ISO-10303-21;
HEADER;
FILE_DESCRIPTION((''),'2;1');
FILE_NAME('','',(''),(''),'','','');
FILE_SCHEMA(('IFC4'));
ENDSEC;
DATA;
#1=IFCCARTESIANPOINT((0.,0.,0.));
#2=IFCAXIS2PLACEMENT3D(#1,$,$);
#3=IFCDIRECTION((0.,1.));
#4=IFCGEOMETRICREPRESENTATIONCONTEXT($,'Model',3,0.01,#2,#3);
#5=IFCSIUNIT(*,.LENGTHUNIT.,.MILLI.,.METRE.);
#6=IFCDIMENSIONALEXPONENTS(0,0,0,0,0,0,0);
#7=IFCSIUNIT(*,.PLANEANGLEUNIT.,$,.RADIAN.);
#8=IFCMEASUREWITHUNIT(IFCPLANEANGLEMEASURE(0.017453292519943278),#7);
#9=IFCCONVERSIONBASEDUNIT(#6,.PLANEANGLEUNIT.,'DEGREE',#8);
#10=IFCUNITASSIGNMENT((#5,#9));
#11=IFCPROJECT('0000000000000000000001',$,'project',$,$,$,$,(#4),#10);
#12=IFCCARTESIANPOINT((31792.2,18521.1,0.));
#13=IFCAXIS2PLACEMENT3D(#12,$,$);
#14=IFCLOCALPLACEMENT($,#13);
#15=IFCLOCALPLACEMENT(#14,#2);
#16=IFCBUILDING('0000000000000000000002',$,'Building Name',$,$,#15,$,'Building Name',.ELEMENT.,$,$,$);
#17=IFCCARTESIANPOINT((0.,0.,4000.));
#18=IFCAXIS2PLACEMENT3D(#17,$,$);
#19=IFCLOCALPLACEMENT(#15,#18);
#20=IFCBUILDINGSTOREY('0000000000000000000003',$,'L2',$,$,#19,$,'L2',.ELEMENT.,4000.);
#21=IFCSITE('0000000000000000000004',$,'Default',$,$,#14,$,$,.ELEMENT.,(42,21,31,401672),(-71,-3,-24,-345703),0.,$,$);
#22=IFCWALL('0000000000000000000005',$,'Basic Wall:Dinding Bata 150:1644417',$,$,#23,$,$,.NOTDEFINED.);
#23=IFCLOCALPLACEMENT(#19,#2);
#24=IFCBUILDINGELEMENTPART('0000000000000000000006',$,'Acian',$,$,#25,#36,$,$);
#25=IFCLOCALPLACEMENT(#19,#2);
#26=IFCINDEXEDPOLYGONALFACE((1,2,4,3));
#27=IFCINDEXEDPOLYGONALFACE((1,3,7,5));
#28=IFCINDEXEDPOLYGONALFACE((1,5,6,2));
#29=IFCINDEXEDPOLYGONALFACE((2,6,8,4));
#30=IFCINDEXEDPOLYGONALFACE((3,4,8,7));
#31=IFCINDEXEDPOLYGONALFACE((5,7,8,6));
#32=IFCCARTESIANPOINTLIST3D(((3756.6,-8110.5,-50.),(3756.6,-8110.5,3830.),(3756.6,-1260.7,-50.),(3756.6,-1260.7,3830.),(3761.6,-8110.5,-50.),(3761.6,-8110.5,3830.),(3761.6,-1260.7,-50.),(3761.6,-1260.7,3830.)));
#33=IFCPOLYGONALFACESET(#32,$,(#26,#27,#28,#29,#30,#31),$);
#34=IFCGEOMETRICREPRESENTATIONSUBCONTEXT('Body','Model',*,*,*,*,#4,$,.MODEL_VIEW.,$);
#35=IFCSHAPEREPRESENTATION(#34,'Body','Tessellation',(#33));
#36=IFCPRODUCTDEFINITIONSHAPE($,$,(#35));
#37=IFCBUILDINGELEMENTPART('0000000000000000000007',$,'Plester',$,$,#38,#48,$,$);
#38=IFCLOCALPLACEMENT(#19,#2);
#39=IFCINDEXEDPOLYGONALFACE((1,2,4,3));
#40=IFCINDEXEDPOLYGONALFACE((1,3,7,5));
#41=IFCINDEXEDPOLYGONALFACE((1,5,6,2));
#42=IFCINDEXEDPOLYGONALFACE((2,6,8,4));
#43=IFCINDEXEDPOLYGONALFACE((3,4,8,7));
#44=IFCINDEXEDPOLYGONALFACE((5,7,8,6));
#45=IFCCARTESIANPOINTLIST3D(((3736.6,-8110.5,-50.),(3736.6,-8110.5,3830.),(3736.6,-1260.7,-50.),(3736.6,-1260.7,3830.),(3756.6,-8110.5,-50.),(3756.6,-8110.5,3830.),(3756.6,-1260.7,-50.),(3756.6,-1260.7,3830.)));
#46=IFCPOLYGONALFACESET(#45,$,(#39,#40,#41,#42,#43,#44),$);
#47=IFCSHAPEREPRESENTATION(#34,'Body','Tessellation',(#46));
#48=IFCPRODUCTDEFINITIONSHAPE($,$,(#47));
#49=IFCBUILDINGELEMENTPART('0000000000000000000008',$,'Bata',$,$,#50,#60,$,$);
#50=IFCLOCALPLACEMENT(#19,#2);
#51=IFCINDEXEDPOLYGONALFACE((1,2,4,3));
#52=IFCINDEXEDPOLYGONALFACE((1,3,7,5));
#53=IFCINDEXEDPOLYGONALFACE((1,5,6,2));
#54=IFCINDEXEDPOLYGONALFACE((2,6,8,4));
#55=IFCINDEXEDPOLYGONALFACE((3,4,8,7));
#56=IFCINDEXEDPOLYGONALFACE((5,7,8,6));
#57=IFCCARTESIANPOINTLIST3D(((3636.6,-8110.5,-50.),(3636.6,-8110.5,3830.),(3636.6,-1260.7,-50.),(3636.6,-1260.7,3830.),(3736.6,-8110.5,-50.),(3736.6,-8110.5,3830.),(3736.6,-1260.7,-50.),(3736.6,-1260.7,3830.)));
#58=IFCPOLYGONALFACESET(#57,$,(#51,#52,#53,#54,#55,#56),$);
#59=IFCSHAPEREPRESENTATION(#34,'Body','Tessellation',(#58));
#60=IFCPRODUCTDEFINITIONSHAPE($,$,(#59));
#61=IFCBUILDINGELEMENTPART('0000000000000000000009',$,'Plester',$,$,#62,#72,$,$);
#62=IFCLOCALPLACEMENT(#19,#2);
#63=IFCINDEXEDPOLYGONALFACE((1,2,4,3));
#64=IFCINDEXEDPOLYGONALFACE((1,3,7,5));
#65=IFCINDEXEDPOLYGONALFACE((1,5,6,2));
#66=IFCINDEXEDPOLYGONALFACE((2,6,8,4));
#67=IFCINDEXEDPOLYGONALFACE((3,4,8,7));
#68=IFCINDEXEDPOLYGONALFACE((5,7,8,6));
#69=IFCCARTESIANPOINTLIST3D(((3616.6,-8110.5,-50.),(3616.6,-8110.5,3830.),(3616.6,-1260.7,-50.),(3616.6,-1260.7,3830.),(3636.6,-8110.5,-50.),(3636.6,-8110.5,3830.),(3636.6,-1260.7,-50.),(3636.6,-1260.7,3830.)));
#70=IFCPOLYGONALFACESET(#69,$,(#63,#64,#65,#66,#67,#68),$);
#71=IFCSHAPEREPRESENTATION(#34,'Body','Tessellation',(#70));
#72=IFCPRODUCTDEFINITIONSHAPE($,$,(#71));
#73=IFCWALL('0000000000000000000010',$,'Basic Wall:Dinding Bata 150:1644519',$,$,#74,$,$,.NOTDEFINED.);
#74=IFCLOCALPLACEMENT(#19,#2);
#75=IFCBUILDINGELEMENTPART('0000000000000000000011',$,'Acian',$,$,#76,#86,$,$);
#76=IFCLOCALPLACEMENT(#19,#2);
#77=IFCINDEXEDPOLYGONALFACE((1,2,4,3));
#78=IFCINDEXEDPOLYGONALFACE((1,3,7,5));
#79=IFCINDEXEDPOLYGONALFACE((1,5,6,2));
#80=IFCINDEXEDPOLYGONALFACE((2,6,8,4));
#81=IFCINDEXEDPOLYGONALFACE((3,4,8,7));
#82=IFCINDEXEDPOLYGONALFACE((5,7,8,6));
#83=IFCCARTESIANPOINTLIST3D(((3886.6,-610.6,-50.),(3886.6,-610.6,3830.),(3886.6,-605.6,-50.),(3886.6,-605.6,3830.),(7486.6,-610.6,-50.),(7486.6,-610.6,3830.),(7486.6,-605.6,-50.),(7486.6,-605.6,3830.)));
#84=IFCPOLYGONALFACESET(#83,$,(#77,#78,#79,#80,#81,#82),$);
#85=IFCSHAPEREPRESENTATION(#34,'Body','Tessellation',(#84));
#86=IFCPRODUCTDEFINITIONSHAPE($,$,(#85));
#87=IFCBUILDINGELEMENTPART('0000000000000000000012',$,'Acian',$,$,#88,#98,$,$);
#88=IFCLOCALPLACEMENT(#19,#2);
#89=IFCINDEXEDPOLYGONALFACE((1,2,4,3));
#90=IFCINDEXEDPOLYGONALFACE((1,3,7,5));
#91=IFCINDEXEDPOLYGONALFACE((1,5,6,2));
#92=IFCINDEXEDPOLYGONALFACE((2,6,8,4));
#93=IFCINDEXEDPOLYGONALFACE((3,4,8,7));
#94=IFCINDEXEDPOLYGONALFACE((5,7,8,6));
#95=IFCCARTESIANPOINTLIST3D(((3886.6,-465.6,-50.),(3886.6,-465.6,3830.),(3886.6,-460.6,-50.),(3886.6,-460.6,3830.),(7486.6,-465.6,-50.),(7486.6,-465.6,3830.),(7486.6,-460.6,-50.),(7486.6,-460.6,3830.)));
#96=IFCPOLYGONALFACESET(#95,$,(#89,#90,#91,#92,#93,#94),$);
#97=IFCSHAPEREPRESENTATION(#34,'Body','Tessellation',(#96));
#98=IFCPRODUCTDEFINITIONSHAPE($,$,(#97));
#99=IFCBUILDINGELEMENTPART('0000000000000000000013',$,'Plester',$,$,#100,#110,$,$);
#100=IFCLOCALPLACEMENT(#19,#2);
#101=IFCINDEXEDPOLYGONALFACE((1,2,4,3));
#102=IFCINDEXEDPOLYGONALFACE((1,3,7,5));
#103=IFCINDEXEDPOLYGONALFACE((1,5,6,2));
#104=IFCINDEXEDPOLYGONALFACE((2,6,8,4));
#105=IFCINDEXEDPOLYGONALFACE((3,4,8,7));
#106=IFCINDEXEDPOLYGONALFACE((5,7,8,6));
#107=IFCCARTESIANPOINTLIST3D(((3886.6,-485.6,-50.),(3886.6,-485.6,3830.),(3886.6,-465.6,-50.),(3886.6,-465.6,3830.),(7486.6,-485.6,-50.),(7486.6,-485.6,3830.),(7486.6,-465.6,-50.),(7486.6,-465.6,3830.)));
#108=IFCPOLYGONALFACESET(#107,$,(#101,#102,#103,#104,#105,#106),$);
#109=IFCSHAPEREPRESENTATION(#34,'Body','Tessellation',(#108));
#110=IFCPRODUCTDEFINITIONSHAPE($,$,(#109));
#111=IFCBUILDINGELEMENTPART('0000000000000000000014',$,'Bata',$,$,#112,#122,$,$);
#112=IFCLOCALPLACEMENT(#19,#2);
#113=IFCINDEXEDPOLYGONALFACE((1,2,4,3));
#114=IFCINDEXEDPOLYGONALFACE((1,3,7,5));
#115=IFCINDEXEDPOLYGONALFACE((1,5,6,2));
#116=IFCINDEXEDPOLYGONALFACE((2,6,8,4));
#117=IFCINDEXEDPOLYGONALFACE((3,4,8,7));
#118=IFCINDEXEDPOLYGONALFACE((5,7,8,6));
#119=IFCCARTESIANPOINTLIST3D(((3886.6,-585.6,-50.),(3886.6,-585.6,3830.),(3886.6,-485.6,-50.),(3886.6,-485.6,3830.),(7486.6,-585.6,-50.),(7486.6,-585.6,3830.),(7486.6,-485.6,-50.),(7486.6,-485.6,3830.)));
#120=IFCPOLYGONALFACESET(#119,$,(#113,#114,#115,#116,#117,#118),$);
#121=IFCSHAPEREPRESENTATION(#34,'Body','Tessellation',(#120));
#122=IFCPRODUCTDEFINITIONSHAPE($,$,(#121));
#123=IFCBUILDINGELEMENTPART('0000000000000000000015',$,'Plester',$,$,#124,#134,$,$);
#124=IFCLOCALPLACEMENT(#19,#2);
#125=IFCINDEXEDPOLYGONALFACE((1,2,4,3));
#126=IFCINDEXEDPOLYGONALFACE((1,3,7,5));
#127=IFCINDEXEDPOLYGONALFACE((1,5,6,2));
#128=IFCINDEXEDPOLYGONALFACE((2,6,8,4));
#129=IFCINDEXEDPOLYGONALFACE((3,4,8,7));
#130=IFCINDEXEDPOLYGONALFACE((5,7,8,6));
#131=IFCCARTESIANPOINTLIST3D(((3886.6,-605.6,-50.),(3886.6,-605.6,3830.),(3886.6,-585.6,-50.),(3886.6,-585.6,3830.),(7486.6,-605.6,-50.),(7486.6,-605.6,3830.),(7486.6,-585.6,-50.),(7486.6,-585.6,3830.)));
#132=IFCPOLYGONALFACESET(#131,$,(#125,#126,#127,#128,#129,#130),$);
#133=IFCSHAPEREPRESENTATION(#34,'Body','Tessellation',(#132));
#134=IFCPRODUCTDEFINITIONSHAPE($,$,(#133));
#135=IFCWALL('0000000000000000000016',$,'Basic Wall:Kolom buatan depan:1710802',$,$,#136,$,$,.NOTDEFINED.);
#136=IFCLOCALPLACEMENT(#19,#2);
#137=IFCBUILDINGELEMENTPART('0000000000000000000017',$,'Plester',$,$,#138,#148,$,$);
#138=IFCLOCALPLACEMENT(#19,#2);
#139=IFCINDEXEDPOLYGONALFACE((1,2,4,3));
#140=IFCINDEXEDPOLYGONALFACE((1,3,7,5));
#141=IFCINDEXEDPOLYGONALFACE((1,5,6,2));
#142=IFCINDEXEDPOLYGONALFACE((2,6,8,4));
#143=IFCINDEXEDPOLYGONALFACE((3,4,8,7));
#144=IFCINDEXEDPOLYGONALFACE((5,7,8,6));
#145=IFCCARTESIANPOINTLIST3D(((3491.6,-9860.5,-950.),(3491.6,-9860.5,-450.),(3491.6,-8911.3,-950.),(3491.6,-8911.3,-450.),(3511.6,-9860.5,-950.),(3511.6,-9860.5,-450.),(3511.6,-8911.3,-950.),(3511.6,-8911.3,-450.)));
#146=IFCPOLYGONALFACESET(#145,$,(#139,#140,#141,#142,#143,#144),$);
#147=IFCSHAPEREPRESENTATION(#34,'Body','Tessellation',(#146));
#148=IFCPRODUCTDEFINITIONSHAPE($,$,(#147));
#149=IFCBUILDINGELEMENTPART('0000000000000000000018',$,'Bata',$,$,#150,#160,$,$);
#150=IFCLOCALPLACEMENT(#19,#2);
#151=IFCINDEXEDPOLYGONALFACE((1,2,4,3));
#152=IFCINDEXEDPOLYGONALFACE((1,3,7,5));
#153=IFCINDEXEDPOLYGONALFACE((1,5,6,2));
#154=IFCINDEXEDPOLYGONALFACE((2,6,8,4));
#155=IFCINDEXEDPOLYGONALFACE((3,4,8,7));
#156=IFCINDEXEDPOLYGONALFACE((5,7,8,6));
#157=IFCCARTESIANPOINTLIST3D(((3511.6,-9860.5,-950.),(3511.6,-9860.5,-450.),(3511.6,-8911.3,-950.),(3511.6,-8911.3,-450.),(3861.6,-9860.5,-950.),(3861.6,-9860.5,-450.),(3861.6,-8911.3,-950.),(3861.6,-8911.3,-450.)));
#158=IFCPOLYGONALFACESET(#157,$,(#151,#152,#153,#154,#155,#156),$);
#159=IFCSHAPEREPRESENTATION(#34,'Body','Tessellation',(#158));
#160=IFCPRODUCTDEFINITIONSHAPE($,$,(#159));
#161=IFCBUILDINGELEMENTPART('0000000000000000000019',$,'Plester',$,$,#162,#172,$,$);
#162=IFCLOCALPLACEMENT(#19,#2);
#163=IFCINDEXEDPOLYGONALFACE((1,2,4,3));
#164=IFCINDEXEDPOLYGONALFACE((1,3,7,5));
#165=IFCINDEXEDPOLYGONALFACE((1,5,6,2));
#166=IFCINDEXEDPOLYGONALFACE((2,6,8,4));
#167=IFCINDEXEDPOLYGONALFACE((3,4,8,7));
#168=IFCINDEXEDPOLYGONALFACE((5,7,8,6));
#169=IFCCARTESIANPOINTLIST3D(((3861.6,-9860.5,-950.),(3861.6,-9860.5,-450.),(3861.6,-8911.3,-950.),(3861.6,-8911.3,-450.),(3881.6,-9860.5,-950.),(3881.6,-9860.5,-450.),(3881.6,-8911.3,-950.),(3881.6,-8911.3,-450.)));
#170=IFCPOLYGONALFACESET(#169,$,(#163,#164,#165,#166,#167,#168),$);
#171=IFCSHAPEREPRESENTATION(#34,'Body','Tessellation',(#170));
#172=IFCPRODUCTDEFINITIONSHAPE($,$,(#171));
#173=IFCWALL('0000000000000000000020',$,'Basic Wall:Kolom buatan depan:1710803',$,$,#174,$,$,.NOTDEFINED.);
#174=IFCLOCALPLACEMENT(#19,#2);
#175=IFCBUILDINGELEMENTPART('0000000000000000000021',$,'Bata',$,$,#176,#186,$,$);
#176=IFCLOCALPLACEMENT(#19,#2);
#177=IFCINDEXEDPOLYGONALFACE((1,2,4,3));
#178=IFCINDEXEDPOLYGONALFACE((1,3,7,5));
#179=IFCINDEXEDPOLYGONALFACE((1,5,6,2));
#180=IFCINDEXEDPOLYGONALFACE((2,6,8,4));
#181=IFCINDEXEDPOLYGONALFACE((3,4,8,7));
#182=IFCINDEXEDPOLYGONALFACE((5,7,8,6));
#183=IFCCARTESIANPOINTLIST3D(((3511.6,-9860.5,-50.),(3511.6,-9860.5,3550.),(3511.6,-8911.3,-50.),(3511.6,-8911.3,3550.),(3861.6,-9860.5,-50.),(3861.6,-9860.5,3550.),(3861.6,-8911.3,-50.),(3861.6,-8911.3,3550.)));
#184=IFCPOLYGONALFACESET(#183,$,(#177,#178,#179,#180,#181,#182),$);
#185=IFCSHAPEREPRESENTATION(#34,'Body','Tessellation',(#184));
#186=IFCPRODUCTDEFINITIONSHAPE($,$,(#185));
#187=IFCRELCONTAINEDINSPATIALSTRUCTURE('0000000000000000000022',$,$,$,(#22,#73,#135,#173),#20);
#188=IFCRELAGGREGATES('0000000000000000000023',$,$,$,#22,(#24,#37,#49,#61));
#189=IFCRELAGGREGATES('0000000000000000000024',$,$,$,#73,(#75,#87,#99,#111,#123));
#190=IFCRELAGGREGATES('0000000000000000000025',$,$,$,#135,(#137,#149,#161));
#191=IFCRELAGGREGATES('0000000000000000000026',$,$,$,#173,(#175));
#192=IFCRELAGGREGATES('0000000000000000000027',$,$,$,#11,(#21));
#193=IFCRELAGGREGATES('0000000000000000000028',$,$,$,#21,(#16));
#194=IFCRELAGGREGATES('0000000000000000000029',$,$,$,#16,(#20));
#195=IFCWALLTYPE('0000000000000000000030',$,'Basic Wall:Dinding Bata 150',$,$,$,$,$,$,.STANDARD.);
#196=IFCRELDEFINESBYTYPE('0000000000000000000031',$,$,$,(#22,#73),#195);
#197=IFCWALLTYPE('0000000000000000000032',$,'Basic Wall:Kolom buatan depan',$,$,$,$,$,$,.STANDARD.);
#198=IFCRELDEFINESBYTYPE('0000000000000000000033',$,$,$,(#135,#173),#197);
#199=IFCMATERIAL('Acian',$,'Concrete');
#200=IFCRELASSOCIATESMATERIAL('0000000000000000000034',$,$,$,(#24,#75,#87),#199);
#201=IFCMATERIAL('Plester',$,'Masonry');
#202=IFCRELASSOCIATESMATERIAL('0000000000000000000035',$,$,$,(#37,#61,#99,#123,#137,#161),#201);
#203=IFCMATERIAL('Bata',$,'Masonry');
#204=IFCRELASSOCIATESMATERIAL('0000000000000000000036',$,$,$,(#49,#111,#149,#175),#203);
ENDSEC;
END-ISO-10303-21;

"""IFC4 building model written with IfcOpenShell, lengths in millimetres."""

from ifc_helpers import new_model, entity, si_unit, converted_unit, direction, frame, origin, place, context, subcontext, project, spatial, indexed_curve, outline, extrude, material, type_object, element, aggregate, save


model = new_model("IFC4")

# Units and contexts
model_context = context("Model", 3, precision=0.01, world=origin(), true_north=direction((0.0, 1.0)))
body_context = subcontext(model_context, "Body", "Model", "MODEL_VIEW")
ifc_project = project(units=[si_unit("LENGTHUNIT", "METRE", prefix="MILLI"), converted_unit("PLANEANGLEUNIT", "DEGREE", entity("IfcPlaneAngleMeasure", 0.017453292519943278), si_unit("PLANEANGLEUNIT", "RADIAN"), dimensions=[0, 0, 0, 0, 0, 0, 0])], contexts=[model_context])

# Site, building, storey
site_placement = place(None, frame((31792.2, 18521.1, 0.0)))
site = spatial("IfcSite", under=ifc_project, at=site_placement, Name="Default", CompositionType="ELEMENT", RefLatitude=(42, 21, 31, 401672), RefLongitude=(-71, -3, -24, -345703), RefElevation=0.0)
building_placement = place(site_placement, origin())
building = spatial("IfcBuilding", under=site, at=building_placement, Name="Building Name", LongName="Building Name", CompositionType="ELEMENT")
storey_placement = place(building_placement, frame((0.0, 0.0, 4000.0)))
storey = spatial("IfcBuildingStorey", under=building, at=storey_placement, Name="L2", LongName="L2", CompositionType="ELEMENT", Elevation=4000.0)

# Walls, building element parts
wall_type_1 = type_object("IfcWallType", Name="Basic Wall:Dinding Bata 150", PredefinedType="STANDARD")
ifc_material_1 = material(Name="Acian", Category="Concrete")
ifc_material_2 = material(Name="Plester", Category="Masonry")
ifc_material_3 = material(Name="Bata", Category="Masonry")
wall_1_placement = place(storey_placement, frame((3686.6, -1260.7, -50.0), z_axis=(0.0, 0.0, 1.0), x_axis=(0.0, -1.0, 0.0)))
wall_1 = element("IfcWall", 1, at=wall_1_placement, inside=storey, type_object=wall_type_1, Name="Basic Wall:Dinding Bata 150:1644417", PredefinedType="NOTDEFINED")
building_element_part_1_placement = place(wall_1_placement, origin())
building_element_part_1 = element("IfcBuildingElementPart", 2, at=building_element_part_1_placement, material=ifc_material_1, Name="Acian", context=body_context, shape_type="SweptSolid", body=[
    extrude(outline(indexed_curve([(-3424.9, -2.5), (3424.9, -2.5), (3424.9, 2.5), (-3424.9, 2.5), (-3424.9, -2.5)], self_intersect=False)), frame((3424.9, 72.5, 0.0)), (0.0, 0.0, 1.0), 3880.0),
])
building_element_part_2_placement = place(wall_1_placement, origin())
building_element_part_2 = element("IfcBuildingElementPart", 3, at=building_element_part_2_placement, material=ifc_material_2, Name="Plester", context=body_context, shape_type="SweptSolid", body=[
    extrude(outline(indexed_curve([(-3424.9, -10.0), (3424.9, -10.0), (3424.9, 10.0), (-3424.9, 10.0), (-3424.9, -10.0)], self_intersect=False)), frame((3424.9, 60.0, 0.0)), (0.0, 0.0, 1.0), 3880.0),
])
building_element_part_3_placement = place(wall_1_placement, origin())
building_element_part_3 = element("IfcBuildingElementPart", 4, at=building_element_part_3_placement, material=ifc_material_3, Name="Bata", context=body_context, shape_type="SweptSolid", body=[
    extrude(outline(indexed_curve([(-3424.9, -50.0), (3424.9, -50.0), (3424.9, 50.0), (-3424.9, 50.0), (-3424.9, -50.0)], self_intersect=False)), frame((3424.9, 0.0, 0.0)), (0.0, 0.0, 1.0), 3880.0),
])
building_element_part_4_placement = place(wall_1_placement, origin())
building_element_part_4 = element("IfcBuildingElementPart", 5, at=building_element_part_4_placement, material=ifc_material_2, Name="Plester", context=body_context, shape_type="SweptSolid", body=[
    extrude(outline(indexed_curve([(-3424.9, -10.0), (3424.9, -10.0), (3424.9, 10.0), (-3424.9, 10.0), (-3424.9, -10.0)], self_intersect=False)), frame((3424.9, -60.0, 0.0)), (0.0, 0.0, 1.0), 3880.0),
])
aggregate(wall_1, [building_element_part_1, building_element_part_2, building_element_part_3, building_element_part_4])
wall_2_placement = place(storey_placement, frame((3886.6, -535.6, -50.0)))
wall_2 = element("IfcWall", 6, at=wall_2_placement, inside=storey, type_object=wall_type_1, Name="Basic Wall:Dinding Bata 150:1644519", PredefinedType="NOTDEFINED")
building_element_part_5_placement = place(wall_2_placement, origin())
building_element_part_5 = element("IfcBuildingElementPart", 7, at=building_element_part_5_placement, material=ifc_material_1, Name="Acian", context=body_context, shape_type="SweptSolid", body=[
    extrude(outline(indexed_curve([(-2.5, -1800.0), (2.5, -1800.0), (2.5, 1800.0), (-2.5, 1800.0), (-2.5, -1800.0)], self_intersect=False)), frame((1800.0, -72.5, 0.0), z_axis=(0.0, 0.0, 1.0), x_axis=(0.0, -1.0, 0.0)), (0.0, 0.0, 1.0), 3880.0),
])
building_element_part_6_placement = place(wall_2_placement, origin())
building_element_part_6 = element("IfcBuildingElementPart", 8, at=building_element_part_6_placement, material=ifc_material_1, Name="Acian", context=body_context, shape_type="SweptSolid", body=[
    extrude(outline(indexed_curve([(-2.5, -1800.0), (2.5, -1800.0), (2.5, 1800.0), (-2.5, 1800.0), (-2.5, -1800.0)], self_intersect=False)), frame((1800.0, 72.5, 0.0), z_axis=(0.0, 0.0, 1.0), x_axis=(0.0, -1.0, 0.0)), (0.0, 0.0, 1.0), 3880.0),
])
building_element_part_7_placement = place(wall_2_placement, origin())
building_element_part_7 = element("IfcBuildingElementPart", 9, at=building_element_part_7_placement, material=ifc_material_2, Name="Plester", context=body_context, shape_type="SweptSolid", body=[
    extrude(outline(indexed_curve([(-10.0, -1800.0), (10.0, -1800.0), (10.0, 1800.0), (-10.0, 1800.0), (-10.0, -1800.0)], self_intersect=False)), frame((1800.0, 60.0, 0.0), z_axis=(0.0, 0.0, 1.0), x_axis=(0.0, -1.0, 0.0)), (0.0, 0.0, 1.0), 3880.0),
])
building_element_part_8_placement = place(wall_2_placement, origin())
building_element_part_8 = element("IfcBuildingElementPart", 10, at=building_element_part_8_placement, material=ifc_material_3, Name="Bata", context=body_context, shape_type="SweptSolid", body=[
    extrude(outline(indexed_curve([(-50.0, -1800.0), (50.0, -1800.0), (50.0, 1800.0), (-50.0, 1800.0), (-50.0, -1800.0)], self_intersect=False)), frame((1800.0, 0.0, 0.0), z_axis=(0.0, 0.0, 1.0), x_axis=(0.0, -1.0, 0.0)), (0.0, 0.0, 1.0), 3880.0),
])
building_element_part_9_placement = place(wall_2_placement, origin())
building_element_part_9 = element("IfcBuildingElementPart", 11, at=building_element_part_9_placement, material=ifc_material_2, Name="Plester", context=body_context, shape_type="SweptSolid", body=[
    extrude(outline(indexed_curve([(-10.0, -1800.0), (10.0, -1800.0), (10.0, 1800.0), (-10.0, 1800.0), (-10.0, -1800.0)], self_intersect=False)), frame((1800.0, -60.0, 0.0), z_axis=(0.0, 0.0, 1.0), x_axis=(0.0, -1.0, 0.0)), (0.0, 0.0, 1.0), 3880.0),
])
aggregate(wall_2, [building_element_part_5, building_element_part_6, building_element_part_7, building_element_part_8, building_element_part_9])
wall_type_2 = type_object("IfcWallType", Name="Basic Wall:Kolom buatan depan", PredefinedType="STANDARD")
wall_3_placement = place(storey_placement, frame((3686.6, -8911.3, -950.0), z_axis=(0.0, 0.0, 1.0), x_axis=(0.0, -1.0, 0.0)))
wall_3 = element("IfcWall", 12, at=wall_3_placement, inside=storey, type_object=wall_type_2, Name="Basic Wall:Kolom buatan depan:1710802", PredefinedType="NOTDEFINED")
building_element_part_10_placement = place(wall_3_placement, origin())
building_element_part_10 = element("IfcBuildingElementPart", 13, at=building_element_part_10_placement, material=ifc_material_2, Name="Plester", context=body_context, shape_type="SweptSolid", body=[
    extrude(outline(indexed_curve([(-474.6, -10.0), (474.6, -10.0), (474.6, 10.0), (-474.6, 10.0), (-474.6, -10.0)], self_intersect=False)), frame((474.6, -185.0, 0.0)), (0.0, 0.0, 1.0), 500.0),
])
building_element_part_11_placement = place(wall_3_placement, origin())
building_element_part_11 = element("IfcBuildingElementPart", 14, at=building_element_part_11_placement, material=ifc_material_3, Name="Bata", context=body_context, shape_type="SweptSolid", body=[
    extrude(outline(indexed_curve([(-474.6, -175.0), (474.6, -175.0), (474.6, 175.0), (-474.6, 175.0), (-474.6, -175.0)], self_intersect=False)), frame((474.6, 0.0, 0.0)), (0.0, 0.0, 1.0), 500.0),
])
building_element_part_12_placement = place(wall_3_placement, origin())
building_element_part_12 = element("IfcBuildingElementPart", 15, at=building_element_part_12_placement, material=ifc_material_2, Name="Plester", context=body_context, shape_type="SweptSolid", body=[
    extrude(outline(indexed_curve([(-474.6, -10.0), (474.6, -10.0), (474.6, 10.0), (-474.6, 10.0), (-474.6, -10.0)], self_intersect=False)), frame((474.6, 185.0, 0.0)), (0.0, 0.0, 1.0), 500.0),
])
aggregate(wall_3, [building_element_part_10, building_element_part_11, building_element_part_12])

# Wall, building element part
wall_4_placement = place(storey_placement, frame((3686.6, -8911.3, -50.0), z_axis=(0.0, 0.0, 1.0), x_axis=(0.0, -1.0, 0.0)))
wall_4 = element("IfcWall", 16, at=wall_4_placement, inside=storey, type_object=wall_type_2, Name="Basic Wall:Kolom buatan depan:1710803", PredefinedType="NOTDEFINED")
building_element_part_13_placement = place(wall_4_placement, origin())
building_element_part_13 = element("IfcBuildingElementPart", 17, at=building_element_part_13_placement, material=ifc_material_3, Name="Bata", context=body_context, shape_type="SweptSolid", body=[
    extrude(outline(indexed_curve([(-474.6, -175.0), (474.6, -175.0), (474.6, 175.0), (-474.6, 175.0), (-474.6, -175.0)], self_intersect=False)), frame((474.6, 0.0, 0.0)), (0.0, 0.0, 1.0), 3600.0),
])
aggregate(wall_4, [building_element_part_13])

save(model, "model.ifc")
